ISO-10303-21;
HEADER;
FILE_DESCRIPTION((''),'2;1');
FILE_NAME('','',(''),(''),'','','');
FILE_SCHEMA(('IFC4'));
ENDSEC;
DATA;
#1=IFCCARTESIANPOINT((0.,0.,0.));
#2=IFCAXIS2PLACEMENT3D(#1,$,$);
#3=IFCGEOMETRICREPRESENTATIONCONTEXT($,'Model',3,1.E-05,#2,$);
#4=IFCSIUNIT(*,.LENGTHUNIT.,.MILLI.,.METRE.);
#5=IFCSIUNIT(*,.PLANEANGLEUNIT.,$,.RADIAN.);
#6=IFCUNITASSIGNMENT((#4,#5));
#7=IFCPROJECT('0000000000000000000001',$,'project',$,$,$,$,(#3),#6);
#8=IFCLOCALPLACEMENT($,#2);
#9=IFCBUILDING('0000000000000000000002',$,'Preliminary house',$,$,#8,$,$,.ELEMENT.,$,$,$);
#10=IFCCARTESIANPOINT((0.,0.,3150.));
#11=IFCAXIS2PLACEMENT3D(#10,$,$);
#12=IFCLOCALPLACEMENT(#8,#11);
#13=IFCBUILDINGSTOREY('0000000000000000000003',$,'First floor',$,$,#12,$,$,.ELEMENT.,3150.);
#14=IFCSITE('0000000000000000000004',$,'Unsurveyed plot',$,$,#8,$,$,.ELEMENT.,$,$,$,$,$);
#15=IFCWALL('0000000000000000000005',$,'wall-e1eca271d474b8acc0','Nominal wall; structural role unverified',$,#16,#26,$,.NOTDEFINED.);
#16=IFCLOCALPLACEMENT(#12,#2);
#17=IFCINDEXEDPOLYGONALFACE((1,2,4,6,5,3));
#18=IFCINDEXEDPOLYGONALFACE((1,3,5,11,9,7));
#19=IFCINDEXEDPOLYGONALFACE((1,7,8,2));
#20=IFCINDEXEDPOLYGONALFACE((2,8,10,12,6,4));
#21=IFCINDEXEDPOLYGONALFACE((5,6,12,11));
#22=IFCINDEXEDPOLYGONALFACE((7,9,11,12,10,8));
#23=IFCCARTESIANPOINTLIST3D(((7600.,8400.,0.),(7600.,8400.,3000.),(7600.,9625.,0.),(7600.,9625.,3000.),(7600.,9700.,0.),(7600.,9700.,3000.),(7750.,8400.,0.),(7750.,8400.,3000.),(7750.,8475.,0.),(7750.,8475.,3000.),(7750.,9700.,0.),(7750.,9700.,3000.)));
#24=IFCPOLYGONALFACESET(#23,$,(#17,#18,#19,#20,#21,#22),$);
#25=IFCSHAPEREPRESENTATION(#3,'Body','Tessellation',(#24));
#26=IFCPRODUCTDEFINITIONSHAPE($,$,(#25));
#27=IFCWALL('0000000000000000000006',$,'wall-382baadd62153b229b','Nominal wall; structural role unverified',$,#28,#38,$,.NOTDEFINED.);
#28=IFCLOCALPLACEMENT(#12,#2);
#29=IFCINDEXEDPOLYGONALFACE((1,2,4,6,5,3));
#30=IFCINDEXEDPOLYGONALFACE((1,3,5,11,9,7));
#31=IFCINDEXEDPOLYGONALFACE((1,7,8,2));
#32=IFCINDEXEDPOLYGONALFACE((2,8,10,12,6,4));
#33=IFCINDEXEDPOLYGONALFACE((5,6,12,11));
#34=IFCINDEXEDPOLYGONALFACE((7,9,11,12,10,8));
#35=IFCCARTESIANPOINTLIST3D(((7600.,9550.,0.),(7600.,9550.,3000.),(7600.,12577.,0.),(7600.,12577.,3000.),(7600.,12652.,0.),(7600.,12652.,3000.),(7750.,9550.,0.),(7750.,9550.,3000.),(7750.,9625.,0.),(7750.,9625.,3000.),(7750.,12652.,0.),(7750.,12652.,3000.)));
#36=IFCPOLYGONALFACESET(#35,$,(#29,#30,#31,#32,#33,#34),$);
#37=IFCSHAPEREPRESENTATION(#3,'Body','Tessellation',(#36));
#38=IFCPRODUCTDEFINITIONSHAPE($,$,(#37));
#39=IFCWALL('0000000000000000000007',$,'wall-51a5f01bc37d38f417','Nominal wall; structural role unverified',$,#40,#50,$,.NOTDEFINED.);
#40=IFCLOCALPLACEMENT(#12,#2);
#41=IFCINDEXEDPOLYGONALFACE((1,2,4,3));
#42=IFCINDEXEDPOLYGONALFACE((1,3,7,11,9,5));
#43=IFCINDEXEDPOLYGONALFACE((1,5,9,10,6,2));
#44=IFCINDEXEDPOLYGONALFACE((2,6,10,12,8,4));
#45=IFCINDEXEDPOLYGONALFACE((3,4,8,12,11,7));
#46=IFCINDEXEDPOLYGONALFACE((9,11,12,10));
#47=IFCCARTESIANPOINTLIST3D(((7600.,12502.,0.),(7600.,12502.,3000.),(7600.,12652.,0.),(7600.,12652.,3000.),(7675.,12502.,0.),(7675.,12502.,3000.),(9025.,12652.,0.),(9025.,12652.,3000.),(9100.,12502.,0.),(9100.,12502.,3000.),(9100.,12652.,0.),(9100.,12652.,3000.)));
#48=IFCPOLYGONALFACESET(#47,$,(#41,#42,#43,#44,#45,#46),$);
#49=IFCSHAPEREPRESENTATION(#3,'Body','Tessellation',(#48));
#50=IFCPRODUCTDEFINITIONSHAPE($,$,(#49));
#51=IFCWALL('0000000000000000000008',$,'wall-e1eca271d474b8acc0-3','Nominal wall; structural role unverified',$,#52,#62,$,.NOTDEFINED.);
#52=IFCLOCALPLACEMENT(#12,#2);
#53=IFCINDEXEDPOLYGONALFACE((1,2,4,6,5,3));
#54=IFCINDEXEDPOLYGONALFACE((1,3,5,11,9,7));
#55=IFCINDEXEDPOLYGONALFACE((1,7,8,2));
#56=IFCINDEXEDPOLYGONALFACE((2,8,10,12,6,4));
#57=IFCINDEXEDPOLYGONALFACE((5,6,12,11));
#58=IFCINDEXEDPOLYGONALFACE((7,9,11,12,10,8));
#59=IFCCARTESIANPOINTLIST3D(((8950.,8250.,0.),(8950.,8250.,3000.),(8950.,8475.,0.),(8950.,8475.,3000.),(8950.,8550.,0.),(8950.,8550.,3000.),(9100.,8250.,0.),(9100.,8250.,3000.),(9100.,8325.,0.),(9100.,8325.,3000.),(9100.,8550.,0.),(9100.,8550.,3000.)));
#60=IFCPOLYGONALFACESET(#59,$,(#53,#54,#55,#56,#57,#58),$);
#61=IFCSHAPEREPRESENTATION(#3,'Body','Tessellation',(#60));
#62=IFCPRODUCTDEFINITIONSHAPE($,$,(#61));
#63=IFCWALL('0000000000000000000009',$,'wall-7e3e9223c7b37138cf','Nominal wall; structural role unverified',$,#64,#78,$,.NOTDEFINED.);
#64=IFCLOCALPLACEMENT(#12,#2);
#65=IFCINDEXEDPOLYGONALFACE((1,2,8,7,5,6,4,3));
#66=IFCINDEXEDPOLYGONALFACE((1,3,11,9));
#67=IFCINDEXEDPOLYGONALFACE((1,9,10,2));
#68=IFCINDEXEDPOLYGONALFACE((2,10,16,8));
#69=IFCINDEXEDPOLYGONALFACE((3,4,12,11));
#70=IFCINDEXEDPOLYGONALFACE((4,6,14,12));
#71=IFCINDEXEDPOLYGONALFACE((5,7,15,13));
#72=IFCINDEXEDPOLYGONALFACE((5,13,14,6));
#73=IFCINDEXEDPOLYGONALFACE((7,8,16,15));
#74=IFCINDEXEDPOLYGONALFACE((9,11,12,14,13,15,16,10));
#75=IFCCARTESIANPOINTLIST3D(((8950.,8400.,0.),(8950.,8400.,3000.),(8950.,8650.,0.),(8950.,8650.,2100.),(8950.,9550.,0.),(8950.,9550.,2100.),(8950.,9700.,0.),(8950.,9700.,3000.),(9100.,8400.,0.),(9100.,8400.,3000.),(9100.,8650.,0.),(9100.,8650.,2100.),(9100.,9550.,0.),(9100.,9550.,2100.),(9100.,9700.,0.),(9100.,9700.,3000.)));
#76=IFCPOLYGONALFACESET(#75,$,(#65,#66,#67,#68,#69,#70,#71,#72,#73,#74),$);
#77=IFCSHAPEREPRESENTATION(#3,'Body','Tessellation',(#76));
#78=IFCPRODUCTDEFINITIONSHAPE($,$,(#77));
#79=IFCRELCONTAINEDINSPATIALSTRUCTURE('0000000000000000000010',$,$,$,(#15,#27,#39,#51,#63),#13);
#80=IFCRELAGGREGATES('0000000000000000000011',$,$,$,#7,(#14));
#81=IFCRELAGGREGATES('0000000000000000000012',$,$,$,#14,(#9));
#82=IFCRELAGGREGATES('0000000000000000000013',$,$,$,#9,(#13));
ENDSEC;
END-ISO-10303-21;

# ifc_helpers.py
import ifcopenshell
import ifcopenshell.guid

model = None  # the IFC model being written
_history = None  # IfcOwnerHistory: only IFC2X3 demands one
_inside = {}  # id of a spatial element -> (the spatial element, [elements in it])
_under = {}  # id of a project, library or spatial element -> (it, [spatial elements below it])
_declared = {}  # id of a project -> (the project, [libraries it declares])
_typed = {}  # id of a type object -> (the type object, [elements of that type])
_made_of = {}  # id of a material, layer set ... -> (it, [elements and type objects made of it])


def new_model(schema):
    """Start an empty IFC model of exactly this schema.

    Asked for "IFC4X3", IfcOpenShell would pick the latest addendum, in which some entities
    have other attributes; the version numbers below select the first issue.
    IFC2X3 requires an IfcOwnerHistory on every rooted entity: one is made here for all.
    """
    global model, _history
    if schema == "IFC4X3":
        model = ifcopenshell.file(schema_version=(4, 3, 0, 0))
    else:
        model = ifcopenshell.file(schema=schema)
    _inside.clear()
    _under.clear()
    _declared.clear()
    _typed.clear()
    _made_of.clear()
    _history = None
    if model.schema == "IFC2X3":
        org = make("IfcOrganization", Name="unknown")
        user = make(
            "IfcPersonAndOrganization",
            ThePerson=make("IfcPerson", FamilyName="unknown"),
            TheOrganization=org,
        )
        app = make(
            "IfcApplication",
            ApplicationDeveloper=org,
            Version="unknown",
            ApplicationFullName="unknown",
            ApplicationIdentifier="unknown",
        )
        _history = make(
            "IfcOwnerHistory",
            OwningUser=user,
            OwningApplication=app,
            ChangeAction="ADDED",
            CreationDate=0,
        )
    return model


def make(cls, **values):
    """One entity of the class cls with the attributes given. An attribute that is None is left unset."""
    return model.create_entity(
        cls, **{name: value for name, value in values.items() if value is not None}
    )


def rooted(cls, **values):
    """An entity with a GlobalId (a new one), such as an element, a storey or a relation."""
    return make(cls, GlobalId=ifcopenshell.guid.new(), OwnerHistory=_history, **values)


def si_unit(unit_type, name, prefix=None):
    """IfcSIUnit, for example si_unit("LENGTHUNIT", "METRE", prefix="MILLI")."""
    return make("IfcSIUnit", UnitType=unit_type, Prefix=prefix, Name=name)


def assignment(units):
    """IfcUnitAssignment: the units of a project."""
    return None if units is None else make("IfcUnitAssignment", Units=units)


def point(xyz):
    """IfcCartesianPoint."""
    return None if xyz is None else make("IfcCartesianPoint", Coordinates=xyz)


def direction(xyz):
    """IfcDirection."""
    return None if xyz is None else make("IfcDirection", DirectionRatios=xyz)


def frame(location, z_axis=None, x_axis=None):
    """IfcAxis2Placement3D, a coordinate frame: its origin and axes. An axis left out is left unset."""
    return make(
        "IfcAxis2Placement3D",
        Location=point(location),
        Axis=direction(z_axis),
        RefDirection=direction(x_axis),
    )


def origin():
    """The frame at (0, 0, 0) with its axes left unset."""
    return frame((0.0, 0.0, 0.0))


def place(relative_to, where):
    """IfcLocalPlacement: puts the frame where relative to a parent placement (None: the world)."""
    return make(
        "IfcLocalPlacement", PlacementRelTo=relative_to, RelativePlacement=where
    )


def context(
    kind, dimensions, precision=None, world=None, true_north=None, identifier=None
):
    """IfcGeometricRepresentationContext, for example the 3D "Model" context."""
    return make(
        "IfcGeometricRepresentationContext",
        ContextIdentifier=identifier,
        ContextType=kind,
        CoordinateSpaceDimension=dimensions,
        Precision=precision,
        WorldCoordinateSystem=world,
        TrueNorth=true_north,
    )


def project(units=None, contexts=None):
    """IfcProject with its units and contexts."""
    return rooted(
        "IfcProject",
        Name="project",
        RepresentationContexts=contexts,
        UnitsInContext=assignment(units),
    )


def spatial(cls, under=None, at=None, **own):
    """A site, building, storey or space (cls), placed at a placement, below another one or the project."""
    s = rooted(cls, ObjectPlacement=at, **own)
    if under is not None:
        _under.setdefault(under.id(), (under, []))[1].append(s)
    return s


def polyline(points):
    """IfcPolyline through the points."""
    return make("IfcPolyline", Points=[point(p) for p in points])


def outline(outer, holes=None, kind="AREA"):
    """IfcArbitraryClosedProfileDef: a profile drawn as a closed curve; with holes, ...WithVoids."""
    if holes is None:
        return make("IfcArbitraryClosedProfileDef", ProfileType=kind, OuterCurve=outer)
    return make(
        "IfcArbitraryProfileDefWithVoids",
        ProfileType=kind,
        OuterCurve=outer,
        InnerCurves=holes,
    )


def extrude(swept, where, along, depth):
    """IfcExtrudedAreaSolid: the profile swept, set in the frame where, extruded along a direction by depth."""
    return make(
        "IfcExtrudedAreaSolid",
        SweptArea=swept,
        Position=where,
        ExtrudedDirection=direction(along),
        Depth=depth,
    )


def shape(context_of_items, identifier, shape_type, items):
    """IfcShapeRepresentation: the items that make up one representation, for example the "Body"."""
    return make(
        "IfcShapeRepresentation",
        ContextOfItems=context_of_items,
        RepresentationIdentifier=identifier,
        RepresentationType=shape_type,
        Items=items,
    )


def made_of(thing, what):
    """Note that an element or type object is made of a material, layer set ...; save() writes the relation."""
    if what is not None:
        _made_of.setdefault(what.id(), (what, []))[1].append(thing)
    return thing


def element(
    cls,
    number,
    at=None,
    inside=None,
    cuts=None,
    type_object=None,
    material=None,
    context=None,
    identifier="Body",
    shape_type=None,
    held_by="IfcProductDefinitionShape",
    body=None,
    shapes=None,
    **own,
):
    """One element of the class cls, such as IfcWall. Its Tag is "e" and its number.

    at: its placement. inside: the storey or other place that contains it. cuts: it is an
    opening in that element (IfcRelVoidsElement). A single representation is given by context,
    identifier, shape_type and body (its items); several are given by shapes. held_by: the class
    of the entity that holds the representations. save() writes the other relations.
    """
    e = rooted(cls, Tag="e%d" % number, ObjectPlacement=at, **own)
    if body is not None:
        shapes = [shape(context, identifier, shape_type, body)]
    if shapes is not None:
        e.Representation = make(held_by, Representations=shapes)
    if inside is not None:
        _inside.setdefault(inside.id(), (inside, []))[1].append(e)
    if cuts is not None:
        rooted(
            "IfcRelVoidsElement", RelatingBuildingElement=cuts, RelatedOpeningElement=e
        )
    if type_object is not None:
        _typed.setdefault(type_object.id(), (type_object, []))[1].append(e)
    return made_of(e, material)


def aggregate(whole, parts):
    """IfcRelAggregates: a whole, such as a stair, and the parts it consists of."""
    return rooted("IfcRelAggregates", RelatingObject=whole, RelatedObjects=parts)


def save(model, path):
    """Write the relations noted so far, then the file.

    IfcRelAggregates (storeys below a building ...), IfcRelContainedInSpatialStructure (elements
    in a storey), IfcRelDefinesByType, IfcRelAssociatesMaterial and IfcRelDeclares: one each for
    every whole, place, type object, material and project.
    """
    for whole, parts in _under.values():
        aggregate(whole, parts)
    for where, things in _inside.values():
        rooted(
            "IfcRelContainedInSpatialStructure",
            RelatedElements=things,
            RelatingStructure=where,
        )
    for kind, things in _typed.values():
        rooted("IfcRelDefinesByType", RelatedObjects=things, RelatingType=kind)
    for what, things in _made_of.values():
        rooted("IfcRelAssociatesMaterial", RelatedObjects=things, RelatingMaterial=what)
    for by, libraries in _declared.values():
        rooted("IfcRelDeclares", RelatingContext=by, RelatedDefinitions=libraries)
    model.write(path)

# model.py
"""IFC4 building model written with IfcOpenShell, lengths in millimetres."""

from ifc_helpers import new_model, si_unit, frame, origin, place, context, project, spatial, polyline, outline, extrude, element, save


model = new_model("IFC4")

# Units and contexts
model_context = context("Model", 3, precision=1e-05, world=origin())
ifc_project = project(units=[si_unit("LENGTHUNIT", "METRE", prefix="MILLI"), si_unit("PLANEANGLEUNIT", "RADIAN")], contexts=[model_context])

# Site, building, storey
placement_1 = place(None, origin())
site = spatial("IfcSite", under=ifc_project, at=placement_1, Name="Unsurveyed plot", CompositionType="ELEMENT")
building = spatial("IfcBuilding", under=site, at=placement_1, Name="Preliminary house", CompositionType="ELEMENT")
placement_2 = place(placement_1, frame((0.0, 0.0, 3150.0)))
storey = spatial("IfcBuildingStorey", under=building, at=placement_2, Name="First floor", CompositionType="ELEMENT", Elevation=3150.0)

# Walls
element("IfcWall", 1, at=placement_2, inside=storey, Name="wall-e1eca271d474b8acc0", Description="Nominal wall; structural role unverified", PredefinedType="NOTDEFINED", context=model_context, shape_type="SweptSolid", body=[
    extrude(outline(polyline([(7600.0, 9625.0), (7600.0, 9700.0), (7750.0, 9700.0), (7750.0, 8475.0), (7750.0, 8400.0), (7600.0, 8400.0), (7600.0, 9625.0)])), origin(), (0.0, 0.0, 1.0), 3000.0),
])
element("IfcWall", 2, at=placement_2, inside=storey, Name="wall-382baadd62153b229b", Description="Nominal wall; structural role unverified", PredefinedType="NOTDEFINED", context=model_context, shape_type="SweptSolid", body=[
    extrude(outline(polyline([(7600.0, 12577.0), (7600.0, 12652.0), (7750.0, 12652.0), (7750.0, 9625.0), (7750.0, 9550.0), (7600.0, 9550.0), (7600.0, 12577.0)])), origin(), (0.0, 0.0, 1.0), 3000.0),
])

# Wall
element("IfcWall", 3, at=placement_2, inside=storey, Name="wall-51a5f01bc37d38f417", Description="Nominal wall; structural role unverified", PredefinedType="NOTDEFINED", context=model_context, shape_type="SweptSolid", body=[
    extrude(outline(polyline([(9025.0, 12652.0), (9100.0, 12652.0), (9100.0, 12502.0), (7675.0, 12502.0), (7600.0, 12502.0), (7600.0, 12652.0), (9025.0, 12652.0)])), origin(), (0.0, 0.0, 1.0), 3000.0),
])

# Wall
element("IfcWall", 4, at=placement_2, inside=storey, Name="wall-e1eca271d474b8acc0-3", Description="Nominal wall; structural role unverified", PredefinedType="NOTDEFINED", context=model_context, shape_type="SweptSolid", body=[
    extrude(outline(polyline([(8950.0, 8475.0), (8950.0, 8550.0), (9100.0, 8550.0), (9100.0, 8325.0), (9100.0, 8250.0), (8950.0, 8250.0), (8950.0, 8475.0)])), origin(), (0.0, 0.0, 1.0), 3000.0),
])

# Wall, opening
wall_1 = element("IfcWall", 5, at=placement_2, inside=storey, Name="wall-7e3e9223c7b37138cf", Description="Nominal wall; structural role unverified", PredefinedType="NOTDEFINED", context=model_context, shape_type="SweptSolid", body=[
    extrude(outline(polyline([(8950.0, 9625.0), (8950.0, 9700.0), (9100.0, 9700.0), (9100.0, 8475.0), (9100.0, 8400.0), (8950.0, 8400.0), (8950.0, 9625.0)])), origin(), (0.0, 0.0, 1.0), 3000.0),
])
element("IfcOpeningElement", 6, at=placement_2, cuts=wall_1, PredefinedType="OPENING", context=model_context, shape_type="SweptSolid", body=[
    extrude(outline(polyline([(9475.0, 8650.0), (9475.0, 9550.0), (8575.0, 9550.0), (8575.0, 8650.0), (9475.0, 8650.0)])), origin(), (0.0, 0.0, 1.0), 2100.0),
])

save(model, "model.ifc")
